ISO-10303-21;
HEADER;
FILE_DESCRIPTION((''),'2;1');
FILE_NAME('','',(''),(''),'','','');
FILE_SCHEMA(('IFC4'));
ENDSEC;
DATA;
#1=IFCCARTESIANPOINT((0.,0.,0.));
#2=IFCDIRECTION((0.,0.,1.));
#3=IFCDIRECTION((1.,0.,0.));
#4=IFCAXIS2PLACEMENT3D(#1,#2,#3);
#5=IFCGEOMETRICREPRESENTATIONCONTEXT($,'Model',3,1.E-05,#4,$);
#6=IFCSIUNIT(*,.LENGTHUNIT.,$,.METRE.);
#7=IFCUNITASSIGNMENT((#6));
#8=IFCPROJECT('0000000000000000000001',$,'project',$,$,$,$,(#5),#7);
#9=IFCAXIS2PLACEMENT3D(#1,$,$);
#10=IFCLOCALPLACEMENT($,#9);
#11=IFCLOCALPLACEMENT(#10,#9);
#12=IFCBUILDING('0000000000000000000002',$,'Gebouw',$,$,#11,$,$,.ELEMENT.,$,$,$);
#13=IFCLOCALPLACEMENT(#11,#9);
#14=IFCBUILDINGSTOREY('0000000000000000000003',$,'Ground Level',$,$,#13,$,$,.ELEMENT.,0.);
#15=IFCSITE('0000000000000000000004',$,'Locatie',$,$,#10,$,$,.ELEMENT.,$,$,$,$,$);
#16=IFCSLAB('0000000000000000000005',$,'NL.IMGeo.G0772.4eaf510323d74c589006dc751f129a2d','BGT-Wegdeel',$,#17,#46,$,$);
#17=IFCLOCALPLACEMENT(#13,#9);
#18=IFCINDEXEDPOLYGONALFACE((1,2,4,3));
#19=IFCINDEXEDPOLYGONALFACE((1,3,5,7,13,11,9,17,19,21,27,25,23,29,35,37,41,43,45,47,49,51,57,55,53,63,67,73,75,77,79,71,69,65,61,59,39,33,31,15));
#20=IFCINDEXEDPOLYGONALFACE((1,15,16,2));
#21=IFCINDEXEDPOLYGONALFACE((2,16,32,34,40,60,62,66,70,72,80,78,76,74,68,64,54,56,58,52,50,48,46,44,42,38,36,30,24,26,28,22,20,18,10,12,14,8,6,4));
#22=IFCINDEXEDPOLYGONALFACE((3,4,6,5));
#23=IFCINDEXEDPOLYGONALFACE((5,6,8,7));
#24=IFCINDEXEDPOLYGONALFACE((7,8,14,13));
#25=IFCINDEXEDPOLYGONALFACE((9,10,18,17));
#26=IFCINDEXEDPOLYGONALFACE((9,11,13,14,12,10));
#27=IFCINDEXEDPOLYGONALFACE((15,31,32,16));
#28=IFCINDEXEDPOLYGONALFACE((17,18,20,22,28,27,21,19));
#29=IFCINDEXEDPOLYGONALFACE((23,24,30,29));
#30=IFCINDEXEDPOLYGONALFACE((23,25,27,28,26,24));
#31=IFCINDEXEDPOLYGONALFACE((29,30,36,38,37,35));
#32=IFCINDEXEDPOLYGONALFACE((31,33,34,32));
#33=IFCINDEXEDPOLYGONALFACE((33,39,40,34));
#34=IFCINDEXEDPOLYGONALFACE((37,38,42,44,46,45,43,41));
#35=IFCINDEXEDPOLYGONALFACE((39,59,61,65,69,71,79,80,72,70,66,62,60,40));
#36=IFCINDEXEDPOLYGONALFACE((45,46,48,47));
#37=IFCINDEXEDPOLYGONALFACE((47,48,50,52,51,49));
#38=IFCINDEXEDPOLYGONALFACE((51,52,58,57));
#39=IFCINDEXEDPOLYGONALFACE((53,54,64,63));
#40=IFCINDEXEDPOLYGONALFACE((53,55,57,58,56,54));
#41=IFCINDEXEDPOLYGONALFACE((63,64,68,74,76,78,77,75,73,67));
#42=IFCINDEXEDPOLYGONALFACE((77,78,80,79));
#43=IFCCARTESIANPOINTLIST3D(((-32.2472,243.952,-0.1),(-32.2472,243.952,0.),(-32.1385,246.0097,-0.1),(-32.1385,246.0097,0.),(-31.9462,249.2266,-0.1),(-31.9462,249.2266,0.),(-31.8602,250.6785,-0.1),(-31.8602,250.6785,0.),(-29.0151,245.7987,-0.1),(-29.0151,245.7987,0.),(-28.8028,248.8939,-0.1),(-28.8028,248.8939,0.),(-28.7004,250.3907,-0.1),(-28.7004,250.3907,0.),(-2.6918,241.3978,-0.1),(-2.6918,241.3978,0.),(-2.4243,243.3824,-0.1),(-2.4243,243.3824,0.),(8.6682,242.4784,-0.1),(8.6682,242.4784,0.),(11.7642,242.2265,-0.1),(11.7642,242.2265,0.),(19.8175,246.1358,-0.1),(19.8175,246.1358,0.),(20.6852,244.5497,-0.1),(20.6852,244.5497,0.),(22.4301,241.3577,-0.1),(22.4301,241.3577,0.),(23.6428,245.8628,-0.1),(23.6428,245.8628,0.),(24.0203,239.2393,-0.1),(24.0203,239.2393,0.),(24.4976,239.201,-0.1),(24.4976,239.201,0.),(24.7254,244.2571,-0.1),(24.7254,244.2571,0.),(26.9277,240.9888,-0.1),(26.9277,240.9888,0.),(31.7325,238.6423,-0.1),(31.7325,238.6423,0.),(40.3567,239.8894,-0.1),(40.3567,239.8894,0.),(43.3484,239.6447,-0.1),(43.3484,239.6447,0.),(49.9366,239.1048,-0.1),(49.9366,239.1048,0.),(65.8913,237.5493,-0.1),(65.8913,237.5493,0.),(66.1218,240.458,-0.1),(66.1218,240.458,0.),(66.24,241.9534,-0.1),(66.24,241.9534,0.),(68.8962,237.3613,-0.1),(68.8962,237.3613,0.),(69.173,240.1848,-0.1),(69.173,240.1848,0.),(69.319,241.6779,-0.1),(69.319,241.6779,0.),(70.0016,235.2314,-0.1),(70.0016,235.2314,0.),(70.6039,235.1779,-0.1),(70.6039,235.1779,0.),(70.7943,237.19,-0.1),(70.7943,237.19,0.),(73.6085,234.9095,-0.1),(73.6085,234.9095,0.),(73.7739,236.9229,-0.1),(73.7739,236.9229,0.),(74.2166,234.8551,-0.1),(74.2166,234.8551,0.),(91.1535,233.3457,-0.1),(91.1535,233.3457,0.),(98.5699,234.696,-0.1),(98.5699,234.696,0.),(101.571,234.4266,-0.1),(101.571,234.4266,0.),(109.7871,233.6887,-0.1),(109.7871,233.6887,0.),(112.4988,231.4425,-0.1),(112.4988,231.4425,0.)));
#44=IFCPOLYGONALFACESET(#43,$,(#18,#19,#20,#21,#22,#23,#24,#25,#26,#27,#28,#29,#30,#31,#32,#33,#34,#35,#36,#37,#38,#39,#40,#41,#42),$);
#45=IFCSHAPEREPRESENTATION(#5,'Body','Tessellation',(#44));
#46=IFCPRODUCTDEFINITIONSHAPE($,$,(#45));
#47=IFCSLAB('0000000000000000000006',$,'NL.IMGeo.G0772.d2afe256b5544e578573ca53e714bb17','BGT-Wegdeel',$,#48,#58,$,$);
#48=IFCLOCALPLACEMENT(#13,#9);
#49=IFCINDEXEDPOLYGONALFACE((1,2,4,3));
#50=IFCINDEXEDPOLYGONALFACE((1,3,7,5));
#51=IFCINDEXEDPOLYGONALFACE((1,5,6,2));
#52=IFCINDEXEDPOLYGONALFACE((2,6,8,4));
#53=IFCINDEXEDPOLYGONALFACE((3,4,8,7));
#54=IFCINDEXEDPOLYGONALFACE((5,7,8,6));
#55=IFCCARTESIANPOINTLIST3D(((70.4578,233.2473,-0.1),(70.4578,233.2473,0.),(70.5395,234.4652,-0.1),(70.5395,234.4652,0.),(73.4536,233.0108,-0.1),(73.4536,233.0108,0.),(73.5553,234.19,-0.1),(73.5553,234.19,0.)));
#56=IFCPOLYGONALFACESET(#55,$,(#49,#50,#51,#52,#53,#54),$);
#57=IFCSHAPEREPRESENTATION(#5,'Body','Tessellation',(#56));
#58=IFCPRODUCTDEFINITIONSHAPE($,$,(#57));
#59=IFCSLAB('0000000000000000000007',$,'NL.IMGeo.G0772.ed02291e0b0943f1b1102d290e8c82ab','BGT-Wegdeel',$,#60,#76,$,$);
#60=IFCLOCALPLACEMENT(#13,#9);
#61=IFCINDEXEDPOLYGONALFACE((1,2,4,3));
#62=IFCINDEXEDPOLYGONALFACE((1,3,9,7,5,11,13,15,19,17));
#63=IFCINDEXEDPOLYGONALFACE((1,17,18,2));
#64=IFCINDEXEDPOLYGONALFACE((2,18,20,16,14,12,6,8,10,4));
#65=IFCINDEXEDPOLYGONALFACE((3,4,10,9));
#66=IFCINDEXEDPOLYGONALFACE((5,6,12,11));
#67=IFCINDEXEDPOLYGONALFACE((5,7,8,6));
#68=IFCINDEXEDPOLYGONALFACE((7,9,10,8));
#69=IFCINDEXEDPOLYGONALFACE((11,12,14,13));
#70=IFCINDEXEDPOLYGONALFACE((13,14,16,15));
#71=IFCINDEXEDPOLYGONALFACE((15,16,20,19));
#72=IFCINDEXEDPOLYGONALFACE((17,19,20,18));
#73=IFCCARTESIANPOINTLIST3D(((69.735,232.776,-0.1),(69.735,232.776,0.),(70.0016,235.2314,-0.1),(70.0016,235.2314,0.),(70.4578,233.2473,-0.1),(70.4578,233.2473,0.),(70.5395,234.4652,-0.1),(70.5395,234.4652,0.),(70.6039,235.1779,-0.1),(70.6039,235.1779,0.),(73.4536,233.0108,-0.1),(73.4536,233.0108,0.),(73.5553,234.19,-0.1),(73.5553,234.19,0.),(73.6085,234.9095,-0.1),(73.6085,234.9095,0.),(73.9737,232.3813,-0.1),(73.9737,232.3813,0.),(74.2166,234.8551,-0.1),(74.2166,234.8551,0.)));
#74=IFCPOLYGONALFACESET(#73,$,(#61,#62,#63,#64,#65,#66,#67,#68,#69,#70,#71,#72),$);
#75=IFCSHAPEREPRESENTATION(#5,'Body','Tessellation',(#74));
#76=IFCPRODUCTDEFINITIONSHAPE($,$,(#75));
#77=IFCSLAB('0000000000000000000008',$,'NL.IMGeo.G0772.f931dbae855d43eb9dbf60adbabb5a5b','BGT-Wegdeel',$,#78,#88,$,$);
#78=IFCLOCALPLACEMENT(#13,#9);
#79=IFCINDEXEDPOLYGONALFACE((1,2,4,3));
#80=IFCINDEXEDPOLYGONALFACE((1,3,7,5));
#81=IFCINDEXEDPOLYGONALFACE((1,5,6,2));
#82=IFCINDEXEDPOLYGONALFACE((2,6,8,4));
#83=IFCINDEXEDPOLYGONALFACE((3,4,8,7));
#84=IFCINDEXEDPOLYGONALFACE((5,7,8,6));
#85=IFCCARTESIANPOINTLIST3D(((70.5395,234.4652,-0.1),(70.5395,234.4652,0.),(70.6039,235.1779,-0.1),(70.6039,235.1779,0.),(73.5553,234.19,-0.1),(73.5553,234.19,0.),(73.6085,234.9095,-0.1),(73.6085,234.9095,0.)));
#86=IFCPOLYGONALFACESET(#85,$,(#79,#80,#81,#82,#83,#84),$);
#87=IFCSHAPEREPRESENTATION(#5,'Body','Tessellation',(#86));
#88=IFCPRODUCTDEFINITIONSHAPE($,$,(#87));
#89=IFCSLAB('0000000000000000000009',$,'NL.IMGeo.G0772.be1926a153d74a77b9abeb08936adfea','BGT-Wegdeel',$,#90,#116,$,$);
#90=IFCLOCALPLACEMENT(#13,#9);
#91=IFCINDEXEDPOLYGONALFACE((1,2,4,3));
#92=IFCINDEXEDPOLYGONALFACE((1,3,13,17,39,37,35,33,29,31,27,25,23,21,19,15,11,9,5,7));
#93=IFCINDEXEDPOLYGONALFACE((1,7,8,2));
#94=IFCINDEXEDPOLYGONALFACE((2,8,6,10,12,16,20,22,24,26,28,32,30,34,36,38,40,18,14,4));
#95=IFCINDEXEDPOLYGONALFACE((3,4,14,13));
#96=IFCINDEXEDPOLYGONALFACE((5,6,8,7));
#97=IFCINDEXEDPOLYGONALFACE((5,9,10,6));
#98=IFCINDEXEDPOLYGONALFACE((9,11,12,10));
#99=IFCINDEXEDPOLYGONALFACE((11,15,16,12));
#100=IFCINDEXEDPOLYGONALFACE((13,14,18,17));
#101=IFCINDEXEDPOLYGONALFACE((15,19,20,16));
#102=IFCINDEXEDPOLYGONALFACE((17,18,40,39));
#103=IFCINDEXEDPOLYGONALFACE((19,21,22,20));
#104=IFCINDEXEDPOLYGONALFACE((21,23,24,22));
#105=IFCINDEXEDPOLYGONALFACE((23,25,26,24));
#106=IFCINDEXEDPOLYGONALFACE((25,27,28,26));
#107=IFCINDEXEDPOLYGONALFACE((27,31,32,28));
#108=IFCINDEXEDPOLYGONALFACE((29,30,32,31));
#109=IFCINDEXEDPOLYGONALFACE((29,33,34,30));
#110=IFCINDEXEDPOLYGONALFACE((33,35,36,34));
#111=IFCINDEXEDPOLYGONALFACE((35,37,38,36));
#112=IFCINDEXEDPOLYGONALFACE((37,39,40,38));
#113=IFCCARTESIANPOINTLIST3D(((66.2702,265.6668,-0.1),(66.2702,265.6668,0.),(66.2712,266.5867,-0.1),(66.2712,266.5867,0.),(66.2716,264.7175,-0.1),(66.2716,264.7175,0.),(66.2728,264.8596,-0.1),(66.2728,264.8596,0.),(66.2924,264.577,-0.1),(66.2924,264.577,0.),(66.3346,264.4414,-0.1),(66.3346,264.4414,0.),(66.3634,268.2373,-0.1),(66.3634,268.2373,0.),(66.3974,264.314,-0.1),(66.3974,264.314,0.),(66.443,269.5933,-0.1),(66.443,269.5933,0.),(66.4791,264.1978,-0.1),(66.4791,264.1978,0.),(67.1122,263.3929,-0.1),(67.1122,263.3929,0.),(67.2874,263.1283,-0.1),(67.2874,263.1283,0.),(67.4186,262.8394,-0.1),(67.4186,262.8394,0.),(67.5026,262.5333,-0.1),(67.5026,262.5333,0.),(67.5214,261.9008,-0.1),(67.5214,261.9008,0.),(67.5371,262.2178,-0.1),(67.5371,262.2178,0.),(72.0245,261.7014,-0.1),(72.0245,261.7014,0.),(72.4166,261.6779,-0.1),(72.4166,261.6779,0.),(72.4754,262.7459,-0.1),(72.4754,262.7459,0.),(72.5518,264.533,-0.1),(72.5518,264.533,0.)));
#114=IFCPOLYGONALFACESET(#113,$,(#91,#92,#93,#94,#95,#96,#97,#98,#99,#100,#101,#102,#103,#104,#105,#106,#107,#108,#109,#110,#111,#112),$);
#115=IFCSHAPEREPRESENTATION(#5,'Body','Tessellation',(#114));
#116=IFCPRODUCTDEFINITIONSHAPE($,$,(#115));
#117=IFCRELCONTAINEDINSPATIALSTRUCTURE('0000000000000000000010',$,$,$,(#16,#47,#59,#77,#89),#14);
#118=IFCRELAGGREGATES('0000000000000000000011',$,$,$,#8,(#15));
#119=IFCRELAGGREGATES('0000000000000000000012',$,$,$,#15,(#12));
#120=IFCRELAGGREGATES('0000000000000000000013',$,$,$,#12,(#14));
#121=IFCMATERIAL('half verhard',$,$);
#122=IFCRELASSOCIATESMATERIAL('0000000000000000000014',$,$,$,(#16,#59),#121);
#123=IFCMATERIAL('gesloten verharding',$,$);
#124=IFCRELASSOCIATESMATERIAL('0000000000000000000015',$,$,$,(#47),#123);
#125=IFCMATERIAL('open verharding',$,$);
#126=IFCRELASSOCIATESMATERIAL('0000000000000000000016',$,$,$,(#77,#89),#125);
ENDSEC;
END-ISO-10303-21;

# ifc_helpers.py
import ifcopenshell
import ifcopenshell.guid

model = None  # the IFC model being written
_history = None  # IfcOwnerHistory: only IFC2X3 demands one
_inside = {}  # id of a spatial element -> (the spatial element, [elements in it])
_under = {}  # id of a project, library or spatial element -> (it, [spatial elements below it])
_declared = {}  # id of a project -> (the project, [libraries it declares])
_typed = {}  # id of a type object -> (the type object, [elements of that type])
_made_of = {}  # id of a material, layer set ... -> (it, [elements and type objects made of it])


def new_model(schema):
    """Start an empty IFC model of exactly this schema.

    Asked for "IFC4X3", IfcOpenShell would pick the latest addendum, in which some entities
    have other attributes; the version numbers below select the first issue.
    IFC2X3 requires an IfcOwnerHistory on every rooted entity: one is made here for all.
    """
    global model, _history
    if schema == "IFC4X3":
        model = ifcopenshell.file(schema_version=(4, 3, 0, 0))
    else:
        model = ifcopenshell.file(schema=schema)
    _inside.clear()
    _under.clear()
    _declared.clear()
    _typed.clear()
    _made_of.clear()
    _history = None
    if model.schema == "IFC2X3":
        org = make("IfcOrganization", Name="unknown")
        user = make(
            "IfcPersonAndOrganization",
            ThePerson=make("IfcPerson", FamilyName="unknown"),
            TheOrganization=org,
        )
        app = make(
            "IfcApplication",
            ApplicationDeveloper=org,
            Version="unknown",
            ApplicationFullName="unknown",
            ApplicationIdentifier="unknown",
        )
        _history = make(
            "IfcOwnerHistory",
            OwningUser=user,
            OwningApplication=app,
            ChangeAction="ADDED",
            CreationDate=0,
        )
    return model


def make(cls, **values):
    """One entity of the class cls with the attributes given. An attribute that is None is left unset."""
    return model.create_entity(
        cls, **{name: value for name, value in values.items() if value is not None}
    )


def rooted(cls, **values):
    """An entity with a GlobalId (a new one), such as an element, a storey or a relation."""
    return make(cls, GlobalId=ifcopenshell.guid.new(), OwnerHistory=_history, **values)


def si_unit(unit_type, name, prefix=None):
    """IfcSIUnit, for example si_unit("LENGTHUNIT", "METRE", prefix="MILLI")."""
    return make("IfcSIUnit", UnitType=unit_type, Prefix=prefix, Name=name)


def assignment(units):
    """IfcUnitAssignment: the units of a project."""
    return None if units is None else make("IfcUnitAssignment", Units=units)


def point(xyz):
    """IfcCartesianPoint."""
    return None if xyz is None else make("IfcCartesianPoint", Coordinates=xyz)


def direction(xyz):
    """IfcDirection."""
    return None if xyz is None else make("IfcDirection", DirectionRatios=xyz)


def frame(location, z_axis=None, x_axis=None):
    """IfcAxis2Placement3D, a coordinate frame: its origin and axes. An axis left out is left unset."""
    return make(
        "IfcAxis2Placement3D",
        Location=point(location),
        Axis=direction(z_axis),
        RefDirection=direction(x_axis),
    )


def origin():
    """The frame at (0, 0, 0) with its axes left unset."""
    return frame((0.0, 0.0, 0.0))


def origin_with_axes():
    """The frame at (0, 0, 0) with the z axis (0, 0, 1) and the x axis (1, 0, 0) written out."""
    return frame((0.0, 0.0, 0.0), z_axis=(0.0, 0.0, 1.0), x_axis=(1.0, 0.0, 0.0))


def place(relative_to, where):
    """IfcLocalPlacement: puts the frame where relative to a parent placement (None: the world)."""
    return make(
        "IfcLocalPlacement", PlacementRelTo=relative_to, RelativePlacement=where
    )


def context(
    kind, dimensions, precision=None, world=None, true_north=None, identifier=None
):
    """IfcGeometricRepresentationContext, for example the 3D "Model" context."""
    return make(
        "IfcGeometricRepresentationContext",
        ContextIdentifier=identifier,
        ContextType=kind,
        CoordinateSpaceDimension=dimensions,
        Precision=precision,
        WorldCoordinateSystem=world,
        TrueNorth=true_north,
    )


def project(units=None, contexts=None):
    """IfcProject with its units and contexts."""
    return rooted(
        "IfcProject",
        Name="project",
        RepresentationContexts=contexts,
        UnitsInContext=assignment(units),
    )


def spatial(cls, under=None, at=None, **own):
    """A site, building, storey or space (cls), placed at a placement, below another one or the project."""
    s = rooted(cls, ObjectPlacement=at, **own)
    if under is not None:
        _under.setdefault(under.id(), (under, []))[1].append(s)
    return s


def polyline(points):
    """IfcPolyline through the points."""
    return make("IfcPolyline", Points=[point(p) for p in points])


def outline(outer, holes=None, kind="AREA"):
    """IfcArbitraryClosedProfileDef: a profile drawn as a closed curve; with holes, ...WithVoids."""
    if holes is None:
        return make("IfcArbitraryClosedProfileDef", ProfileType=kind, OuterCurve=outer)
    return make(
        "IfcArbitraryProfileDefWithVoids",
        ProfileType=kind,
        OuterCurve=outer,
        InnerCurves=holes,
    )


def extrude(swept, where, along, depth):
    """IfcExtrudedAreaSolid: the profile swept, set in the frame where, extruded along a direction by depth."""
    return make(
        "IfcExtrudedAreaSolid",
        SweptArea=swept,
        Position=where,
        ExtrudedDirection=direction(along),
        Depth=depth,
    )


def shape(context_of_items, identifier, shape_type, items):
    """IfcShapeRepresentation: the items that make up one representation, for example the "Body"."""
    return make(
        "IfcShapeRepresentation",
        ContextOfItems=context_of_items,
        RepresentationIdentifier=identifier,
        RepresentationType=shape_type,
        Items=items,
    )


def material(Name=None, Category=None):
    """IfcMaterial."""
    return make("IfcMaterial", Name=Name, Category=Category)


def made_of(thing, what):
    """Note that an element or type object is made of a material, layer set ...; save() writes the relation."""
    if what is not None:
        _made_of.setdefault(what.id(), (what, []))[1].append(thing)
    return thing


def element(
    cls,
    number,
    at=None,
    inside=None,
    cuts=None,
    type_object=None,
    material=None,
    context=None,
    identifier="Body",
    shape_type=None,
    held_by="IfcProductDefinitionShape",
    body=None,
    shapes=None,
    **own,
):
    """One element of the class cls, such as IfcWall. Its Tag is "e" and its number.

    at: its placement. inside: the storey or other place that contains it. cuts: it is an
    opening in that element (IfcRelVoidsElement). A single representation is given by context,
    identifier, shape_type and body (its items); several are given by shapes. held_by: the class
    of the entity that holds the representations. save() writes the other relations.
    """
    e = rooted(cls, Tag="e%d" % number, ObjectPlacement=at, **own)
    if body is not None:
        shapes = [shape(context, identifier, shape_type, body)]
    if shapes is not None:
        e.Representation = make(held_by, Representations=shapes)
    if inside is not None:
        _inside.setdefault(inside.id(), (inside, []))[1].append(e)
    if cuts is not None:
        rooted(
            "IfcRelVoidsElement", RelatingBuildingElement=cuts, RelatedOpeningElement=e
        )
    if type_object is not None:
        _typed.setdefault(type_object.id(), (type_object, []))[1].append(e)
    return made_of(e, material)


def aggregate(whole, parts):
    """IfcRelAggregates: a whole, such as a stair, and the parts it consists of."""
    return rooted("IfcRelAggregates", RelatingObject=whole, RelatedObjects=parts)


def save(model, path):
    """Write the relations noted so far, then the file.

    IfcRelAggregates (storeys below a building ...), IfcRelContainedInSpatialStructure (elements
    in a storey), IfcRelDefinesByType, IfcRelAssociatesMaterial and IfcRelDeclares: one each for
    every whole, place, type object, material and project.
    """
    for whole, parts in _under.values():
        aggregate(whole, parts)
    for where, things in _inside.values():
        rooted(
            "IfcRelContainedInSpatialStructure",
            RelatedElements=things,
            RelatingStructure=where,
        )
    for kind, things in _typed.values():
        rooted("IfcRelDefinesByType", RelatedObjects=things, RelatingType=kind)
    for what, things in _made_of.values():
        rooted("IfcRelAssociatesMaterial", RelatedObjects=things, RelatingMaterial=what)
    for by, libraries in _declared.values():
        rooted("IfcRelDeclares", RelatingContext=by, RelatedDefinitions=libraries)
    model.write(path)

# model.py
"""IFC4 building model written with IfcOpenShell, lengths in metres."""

from ifc_helpers import new_model, si_unit, frame, origin, origin_with_axes, place, context, project, spatial, polyline, outline, extrude, material, element, save


model = new_model("IFC4")

# Units and contexts
model_context = context("Model", 3, precision=1e-05, world=origin_with_axes())
ifc_project = project(units=[si_unit("LENGTHUNIT", "METRE")], contexts=[model_context])

# Site, building, storey
site_placement = place(None, origin())
site = spatial("IfcSite", under=ifc_project, at=site_placement, Name="Locatie", CompositionType="ELEMENT")
building_placement = place(site_placement, origin())
building = spatial("IfcBuilding", under=site, at=building_placement, Name="Gebouw", CompositionType="ELEMENT")
storey_placement = place(building_placement, origin())
storey = spatial("IfcBuildingStorey", under=building, at=storey_placement, Name="Ground Level", CompositionType="ELEMENT", Elevation=0.0)

# Slabs
ifc_material_1 = material(Name="open verharding")
ifc_material_2 = material(Name="gesloten verharding")
ifc_material_3 = material(Name="half verhard")
slab_1_placement = place(storey_placement, origin())
element("IfcSlab", 1, at=slab_1_placement, inside=storey, material=ifc_material_3, Name="NL.IMGeo.G0772.4eaf510323d74c589006dc751f129a2d", Description="BGT-Wegdeel", context=model_context, shape_type="SweptSolid", body=[
    extrude(outline(polyline([(91.1535, 233.3457), (74.2166, 234.8551), (73.6085, 234.9095), (70.6039, 235.1779), (70.0016, 235.2314), (31.7325, 238.6423), (24.4976, 239.201), (24.0203, 239.2393), (-2.6918, 241.3978), (-32.2472, 243.952), (-32.1385, 246.0097), (-31.9462, 249.2266), (-31.8602, 250.6785), (-28.7004, 250.3907), (-28.8028, 248.8939), (-29.0151, 245.7987), (-2.4243, 243.3824), (8.6682, 242.4784), (11.7642, 242.2265), (22.4301, 241.3577), (20.6852, 244.5497), (19.8175, 246.1358), (23.6428, 245.8628), (24.7254, 244.2571), (26.9277, 240.9888), (40.3567, 239.8894), (43.3484, 239.6447), (49.9366, 239.1048), (65.8913, 237.5493), (66.1218, 240.458), (66.24, 241.9534), (69.319, 241.6779), (69.173, 240.1848), (68.8962, 237.3613), (70.7943, 237.19), (73.7739, 236.9229), (98.5699, 234.696), (101.571, 234.4266), (109.7871, 233.6887), (112.4988, 231.4425), (91.1535, 233.3457)])), frame((0.0, 0.0, -0.1), z_axis=(0.0, 0.0, 1.0), x_axis=(1.0, 0.0, 0.0)), (0.0, 0.0, 1.0), 0.1),
])
slab_2_placement = place(storey_placement, origin())
element("IfcSlab", 2, at=slab_2_placement, inside=storey, material=ifc_material_2, Name="NL.IMGeo.G0772.d2afe256b5544e578573ca53e714bb17", Description="BGT-Wegdeel", context=model_context, shape_type="SweptSolid", body=[
    extrude(outline(polyline([(73.5553, 234.19), (73.4536, 233.0108), (70.4578, 233.2473), (70.5395, 234.4652), (73.5553, 234.19)])), frame((0.0, 0.0, -0.1), z_axis=(0.0, 0.0, 1.0), x_axis=(1.0, 0.0, 0.0)), (0.0, 0.0, 1.0), 0.1),
])
slab_3_placement = place(storey_placement, origin())
element("IfcSlab", 3, at=slab_3_placement, inside=storey, material=ifc_material_3, Name="NL.IMGeo.G0772.ed02291e0b0943f1b1102d290e8c82ab", Description="BGT-Wegdeel", context=model_context, shape_type="SweptSolid", body=[
    extrude(outline(polyline([(70.4578, 233.2473), (73.4536, 233.0108), (73.5553, 234.19), (73.6085, 234.9095), (74.2166, 234.8551), (73.9737, 232.3813), (69.735, 232.776), (70.0016, 235.2314), (70.6039, 235.1779), (70.5395, 234.4652), (70.4578, 233.2473)])), frame((0.0, 0.0, -0.1), z_axis=(0.0, 0.0, 1.0), x_axis=(1.0, 0.0, 0.0)), (0.0, 0.0, 1.0), 0.1),
])
slab_4_placement = place(storey_placement, origin())
element("IfcSlab", 4, at=slab_4_placement, inside=storey, material=ifc_material_1, Name="NL.IMGeo.G0772.f931dbae855d43eb9dbf60adbabb5a5b", Description="BGT-Wegdeel", context=model_context, shape_type="SweptSolid", body=[
    extrude(outline(polyline([(73.6085, 234.9095), (73.5553, 234.19), (70.5395, 234.4652), (70.6039, 235.1779), (73.6085, 234.9095)])), frame((0.0, 0.0, -0.1), z_axis=(0.0, 0.0, 1.0), x_axis=(1.0, 0.0, 0.0)), (0.0, 0.0, 1.0), 0.1),
])
slab_5_placement = place(storey_placement, origin())
element("IfcSlab", 5, at=slab_5_placement, inside=storey, material=ifc_material_1, Name="NL.IMGeo.G0772.be1926a153d74a77b9abeb08936adfea", Description="BGT-Wegdeel", context=model_context, shape_type="SweptSolid", body=[
    extrude(outline(polyline([(72.4754, 262.7459), (72.4166, 261.6779), (72.0245, 261.7014), (67.5214, 261.9008), (67.5371, 262.2178), (67.5026, 262.5333), (67.4186, 262.8394), (67.2874, 263.1283), (67.1122, 263.3929), (66.4791, 264.1978), (66.3974, 264.314), (66.3346, 264.4414), (66.2924, 264.577), (66.2716, 264.7175), (66.2728, 264.8596), (66.2702, 265.6668), (66.2712, 266.5867), (66.3634, 268.2373), (66.443, 269.5933), (72.5518, 264.533), (72.4754, 262.7459)])), frame((0.0, 0.0, -0.1), z_axis=(0.0, 0.0, 1.0), x_axis=(1.0, 0.0, 0.0)), (0.0, 0.0, 1.0), 0.1),
])

save(model, "model.ifc")
